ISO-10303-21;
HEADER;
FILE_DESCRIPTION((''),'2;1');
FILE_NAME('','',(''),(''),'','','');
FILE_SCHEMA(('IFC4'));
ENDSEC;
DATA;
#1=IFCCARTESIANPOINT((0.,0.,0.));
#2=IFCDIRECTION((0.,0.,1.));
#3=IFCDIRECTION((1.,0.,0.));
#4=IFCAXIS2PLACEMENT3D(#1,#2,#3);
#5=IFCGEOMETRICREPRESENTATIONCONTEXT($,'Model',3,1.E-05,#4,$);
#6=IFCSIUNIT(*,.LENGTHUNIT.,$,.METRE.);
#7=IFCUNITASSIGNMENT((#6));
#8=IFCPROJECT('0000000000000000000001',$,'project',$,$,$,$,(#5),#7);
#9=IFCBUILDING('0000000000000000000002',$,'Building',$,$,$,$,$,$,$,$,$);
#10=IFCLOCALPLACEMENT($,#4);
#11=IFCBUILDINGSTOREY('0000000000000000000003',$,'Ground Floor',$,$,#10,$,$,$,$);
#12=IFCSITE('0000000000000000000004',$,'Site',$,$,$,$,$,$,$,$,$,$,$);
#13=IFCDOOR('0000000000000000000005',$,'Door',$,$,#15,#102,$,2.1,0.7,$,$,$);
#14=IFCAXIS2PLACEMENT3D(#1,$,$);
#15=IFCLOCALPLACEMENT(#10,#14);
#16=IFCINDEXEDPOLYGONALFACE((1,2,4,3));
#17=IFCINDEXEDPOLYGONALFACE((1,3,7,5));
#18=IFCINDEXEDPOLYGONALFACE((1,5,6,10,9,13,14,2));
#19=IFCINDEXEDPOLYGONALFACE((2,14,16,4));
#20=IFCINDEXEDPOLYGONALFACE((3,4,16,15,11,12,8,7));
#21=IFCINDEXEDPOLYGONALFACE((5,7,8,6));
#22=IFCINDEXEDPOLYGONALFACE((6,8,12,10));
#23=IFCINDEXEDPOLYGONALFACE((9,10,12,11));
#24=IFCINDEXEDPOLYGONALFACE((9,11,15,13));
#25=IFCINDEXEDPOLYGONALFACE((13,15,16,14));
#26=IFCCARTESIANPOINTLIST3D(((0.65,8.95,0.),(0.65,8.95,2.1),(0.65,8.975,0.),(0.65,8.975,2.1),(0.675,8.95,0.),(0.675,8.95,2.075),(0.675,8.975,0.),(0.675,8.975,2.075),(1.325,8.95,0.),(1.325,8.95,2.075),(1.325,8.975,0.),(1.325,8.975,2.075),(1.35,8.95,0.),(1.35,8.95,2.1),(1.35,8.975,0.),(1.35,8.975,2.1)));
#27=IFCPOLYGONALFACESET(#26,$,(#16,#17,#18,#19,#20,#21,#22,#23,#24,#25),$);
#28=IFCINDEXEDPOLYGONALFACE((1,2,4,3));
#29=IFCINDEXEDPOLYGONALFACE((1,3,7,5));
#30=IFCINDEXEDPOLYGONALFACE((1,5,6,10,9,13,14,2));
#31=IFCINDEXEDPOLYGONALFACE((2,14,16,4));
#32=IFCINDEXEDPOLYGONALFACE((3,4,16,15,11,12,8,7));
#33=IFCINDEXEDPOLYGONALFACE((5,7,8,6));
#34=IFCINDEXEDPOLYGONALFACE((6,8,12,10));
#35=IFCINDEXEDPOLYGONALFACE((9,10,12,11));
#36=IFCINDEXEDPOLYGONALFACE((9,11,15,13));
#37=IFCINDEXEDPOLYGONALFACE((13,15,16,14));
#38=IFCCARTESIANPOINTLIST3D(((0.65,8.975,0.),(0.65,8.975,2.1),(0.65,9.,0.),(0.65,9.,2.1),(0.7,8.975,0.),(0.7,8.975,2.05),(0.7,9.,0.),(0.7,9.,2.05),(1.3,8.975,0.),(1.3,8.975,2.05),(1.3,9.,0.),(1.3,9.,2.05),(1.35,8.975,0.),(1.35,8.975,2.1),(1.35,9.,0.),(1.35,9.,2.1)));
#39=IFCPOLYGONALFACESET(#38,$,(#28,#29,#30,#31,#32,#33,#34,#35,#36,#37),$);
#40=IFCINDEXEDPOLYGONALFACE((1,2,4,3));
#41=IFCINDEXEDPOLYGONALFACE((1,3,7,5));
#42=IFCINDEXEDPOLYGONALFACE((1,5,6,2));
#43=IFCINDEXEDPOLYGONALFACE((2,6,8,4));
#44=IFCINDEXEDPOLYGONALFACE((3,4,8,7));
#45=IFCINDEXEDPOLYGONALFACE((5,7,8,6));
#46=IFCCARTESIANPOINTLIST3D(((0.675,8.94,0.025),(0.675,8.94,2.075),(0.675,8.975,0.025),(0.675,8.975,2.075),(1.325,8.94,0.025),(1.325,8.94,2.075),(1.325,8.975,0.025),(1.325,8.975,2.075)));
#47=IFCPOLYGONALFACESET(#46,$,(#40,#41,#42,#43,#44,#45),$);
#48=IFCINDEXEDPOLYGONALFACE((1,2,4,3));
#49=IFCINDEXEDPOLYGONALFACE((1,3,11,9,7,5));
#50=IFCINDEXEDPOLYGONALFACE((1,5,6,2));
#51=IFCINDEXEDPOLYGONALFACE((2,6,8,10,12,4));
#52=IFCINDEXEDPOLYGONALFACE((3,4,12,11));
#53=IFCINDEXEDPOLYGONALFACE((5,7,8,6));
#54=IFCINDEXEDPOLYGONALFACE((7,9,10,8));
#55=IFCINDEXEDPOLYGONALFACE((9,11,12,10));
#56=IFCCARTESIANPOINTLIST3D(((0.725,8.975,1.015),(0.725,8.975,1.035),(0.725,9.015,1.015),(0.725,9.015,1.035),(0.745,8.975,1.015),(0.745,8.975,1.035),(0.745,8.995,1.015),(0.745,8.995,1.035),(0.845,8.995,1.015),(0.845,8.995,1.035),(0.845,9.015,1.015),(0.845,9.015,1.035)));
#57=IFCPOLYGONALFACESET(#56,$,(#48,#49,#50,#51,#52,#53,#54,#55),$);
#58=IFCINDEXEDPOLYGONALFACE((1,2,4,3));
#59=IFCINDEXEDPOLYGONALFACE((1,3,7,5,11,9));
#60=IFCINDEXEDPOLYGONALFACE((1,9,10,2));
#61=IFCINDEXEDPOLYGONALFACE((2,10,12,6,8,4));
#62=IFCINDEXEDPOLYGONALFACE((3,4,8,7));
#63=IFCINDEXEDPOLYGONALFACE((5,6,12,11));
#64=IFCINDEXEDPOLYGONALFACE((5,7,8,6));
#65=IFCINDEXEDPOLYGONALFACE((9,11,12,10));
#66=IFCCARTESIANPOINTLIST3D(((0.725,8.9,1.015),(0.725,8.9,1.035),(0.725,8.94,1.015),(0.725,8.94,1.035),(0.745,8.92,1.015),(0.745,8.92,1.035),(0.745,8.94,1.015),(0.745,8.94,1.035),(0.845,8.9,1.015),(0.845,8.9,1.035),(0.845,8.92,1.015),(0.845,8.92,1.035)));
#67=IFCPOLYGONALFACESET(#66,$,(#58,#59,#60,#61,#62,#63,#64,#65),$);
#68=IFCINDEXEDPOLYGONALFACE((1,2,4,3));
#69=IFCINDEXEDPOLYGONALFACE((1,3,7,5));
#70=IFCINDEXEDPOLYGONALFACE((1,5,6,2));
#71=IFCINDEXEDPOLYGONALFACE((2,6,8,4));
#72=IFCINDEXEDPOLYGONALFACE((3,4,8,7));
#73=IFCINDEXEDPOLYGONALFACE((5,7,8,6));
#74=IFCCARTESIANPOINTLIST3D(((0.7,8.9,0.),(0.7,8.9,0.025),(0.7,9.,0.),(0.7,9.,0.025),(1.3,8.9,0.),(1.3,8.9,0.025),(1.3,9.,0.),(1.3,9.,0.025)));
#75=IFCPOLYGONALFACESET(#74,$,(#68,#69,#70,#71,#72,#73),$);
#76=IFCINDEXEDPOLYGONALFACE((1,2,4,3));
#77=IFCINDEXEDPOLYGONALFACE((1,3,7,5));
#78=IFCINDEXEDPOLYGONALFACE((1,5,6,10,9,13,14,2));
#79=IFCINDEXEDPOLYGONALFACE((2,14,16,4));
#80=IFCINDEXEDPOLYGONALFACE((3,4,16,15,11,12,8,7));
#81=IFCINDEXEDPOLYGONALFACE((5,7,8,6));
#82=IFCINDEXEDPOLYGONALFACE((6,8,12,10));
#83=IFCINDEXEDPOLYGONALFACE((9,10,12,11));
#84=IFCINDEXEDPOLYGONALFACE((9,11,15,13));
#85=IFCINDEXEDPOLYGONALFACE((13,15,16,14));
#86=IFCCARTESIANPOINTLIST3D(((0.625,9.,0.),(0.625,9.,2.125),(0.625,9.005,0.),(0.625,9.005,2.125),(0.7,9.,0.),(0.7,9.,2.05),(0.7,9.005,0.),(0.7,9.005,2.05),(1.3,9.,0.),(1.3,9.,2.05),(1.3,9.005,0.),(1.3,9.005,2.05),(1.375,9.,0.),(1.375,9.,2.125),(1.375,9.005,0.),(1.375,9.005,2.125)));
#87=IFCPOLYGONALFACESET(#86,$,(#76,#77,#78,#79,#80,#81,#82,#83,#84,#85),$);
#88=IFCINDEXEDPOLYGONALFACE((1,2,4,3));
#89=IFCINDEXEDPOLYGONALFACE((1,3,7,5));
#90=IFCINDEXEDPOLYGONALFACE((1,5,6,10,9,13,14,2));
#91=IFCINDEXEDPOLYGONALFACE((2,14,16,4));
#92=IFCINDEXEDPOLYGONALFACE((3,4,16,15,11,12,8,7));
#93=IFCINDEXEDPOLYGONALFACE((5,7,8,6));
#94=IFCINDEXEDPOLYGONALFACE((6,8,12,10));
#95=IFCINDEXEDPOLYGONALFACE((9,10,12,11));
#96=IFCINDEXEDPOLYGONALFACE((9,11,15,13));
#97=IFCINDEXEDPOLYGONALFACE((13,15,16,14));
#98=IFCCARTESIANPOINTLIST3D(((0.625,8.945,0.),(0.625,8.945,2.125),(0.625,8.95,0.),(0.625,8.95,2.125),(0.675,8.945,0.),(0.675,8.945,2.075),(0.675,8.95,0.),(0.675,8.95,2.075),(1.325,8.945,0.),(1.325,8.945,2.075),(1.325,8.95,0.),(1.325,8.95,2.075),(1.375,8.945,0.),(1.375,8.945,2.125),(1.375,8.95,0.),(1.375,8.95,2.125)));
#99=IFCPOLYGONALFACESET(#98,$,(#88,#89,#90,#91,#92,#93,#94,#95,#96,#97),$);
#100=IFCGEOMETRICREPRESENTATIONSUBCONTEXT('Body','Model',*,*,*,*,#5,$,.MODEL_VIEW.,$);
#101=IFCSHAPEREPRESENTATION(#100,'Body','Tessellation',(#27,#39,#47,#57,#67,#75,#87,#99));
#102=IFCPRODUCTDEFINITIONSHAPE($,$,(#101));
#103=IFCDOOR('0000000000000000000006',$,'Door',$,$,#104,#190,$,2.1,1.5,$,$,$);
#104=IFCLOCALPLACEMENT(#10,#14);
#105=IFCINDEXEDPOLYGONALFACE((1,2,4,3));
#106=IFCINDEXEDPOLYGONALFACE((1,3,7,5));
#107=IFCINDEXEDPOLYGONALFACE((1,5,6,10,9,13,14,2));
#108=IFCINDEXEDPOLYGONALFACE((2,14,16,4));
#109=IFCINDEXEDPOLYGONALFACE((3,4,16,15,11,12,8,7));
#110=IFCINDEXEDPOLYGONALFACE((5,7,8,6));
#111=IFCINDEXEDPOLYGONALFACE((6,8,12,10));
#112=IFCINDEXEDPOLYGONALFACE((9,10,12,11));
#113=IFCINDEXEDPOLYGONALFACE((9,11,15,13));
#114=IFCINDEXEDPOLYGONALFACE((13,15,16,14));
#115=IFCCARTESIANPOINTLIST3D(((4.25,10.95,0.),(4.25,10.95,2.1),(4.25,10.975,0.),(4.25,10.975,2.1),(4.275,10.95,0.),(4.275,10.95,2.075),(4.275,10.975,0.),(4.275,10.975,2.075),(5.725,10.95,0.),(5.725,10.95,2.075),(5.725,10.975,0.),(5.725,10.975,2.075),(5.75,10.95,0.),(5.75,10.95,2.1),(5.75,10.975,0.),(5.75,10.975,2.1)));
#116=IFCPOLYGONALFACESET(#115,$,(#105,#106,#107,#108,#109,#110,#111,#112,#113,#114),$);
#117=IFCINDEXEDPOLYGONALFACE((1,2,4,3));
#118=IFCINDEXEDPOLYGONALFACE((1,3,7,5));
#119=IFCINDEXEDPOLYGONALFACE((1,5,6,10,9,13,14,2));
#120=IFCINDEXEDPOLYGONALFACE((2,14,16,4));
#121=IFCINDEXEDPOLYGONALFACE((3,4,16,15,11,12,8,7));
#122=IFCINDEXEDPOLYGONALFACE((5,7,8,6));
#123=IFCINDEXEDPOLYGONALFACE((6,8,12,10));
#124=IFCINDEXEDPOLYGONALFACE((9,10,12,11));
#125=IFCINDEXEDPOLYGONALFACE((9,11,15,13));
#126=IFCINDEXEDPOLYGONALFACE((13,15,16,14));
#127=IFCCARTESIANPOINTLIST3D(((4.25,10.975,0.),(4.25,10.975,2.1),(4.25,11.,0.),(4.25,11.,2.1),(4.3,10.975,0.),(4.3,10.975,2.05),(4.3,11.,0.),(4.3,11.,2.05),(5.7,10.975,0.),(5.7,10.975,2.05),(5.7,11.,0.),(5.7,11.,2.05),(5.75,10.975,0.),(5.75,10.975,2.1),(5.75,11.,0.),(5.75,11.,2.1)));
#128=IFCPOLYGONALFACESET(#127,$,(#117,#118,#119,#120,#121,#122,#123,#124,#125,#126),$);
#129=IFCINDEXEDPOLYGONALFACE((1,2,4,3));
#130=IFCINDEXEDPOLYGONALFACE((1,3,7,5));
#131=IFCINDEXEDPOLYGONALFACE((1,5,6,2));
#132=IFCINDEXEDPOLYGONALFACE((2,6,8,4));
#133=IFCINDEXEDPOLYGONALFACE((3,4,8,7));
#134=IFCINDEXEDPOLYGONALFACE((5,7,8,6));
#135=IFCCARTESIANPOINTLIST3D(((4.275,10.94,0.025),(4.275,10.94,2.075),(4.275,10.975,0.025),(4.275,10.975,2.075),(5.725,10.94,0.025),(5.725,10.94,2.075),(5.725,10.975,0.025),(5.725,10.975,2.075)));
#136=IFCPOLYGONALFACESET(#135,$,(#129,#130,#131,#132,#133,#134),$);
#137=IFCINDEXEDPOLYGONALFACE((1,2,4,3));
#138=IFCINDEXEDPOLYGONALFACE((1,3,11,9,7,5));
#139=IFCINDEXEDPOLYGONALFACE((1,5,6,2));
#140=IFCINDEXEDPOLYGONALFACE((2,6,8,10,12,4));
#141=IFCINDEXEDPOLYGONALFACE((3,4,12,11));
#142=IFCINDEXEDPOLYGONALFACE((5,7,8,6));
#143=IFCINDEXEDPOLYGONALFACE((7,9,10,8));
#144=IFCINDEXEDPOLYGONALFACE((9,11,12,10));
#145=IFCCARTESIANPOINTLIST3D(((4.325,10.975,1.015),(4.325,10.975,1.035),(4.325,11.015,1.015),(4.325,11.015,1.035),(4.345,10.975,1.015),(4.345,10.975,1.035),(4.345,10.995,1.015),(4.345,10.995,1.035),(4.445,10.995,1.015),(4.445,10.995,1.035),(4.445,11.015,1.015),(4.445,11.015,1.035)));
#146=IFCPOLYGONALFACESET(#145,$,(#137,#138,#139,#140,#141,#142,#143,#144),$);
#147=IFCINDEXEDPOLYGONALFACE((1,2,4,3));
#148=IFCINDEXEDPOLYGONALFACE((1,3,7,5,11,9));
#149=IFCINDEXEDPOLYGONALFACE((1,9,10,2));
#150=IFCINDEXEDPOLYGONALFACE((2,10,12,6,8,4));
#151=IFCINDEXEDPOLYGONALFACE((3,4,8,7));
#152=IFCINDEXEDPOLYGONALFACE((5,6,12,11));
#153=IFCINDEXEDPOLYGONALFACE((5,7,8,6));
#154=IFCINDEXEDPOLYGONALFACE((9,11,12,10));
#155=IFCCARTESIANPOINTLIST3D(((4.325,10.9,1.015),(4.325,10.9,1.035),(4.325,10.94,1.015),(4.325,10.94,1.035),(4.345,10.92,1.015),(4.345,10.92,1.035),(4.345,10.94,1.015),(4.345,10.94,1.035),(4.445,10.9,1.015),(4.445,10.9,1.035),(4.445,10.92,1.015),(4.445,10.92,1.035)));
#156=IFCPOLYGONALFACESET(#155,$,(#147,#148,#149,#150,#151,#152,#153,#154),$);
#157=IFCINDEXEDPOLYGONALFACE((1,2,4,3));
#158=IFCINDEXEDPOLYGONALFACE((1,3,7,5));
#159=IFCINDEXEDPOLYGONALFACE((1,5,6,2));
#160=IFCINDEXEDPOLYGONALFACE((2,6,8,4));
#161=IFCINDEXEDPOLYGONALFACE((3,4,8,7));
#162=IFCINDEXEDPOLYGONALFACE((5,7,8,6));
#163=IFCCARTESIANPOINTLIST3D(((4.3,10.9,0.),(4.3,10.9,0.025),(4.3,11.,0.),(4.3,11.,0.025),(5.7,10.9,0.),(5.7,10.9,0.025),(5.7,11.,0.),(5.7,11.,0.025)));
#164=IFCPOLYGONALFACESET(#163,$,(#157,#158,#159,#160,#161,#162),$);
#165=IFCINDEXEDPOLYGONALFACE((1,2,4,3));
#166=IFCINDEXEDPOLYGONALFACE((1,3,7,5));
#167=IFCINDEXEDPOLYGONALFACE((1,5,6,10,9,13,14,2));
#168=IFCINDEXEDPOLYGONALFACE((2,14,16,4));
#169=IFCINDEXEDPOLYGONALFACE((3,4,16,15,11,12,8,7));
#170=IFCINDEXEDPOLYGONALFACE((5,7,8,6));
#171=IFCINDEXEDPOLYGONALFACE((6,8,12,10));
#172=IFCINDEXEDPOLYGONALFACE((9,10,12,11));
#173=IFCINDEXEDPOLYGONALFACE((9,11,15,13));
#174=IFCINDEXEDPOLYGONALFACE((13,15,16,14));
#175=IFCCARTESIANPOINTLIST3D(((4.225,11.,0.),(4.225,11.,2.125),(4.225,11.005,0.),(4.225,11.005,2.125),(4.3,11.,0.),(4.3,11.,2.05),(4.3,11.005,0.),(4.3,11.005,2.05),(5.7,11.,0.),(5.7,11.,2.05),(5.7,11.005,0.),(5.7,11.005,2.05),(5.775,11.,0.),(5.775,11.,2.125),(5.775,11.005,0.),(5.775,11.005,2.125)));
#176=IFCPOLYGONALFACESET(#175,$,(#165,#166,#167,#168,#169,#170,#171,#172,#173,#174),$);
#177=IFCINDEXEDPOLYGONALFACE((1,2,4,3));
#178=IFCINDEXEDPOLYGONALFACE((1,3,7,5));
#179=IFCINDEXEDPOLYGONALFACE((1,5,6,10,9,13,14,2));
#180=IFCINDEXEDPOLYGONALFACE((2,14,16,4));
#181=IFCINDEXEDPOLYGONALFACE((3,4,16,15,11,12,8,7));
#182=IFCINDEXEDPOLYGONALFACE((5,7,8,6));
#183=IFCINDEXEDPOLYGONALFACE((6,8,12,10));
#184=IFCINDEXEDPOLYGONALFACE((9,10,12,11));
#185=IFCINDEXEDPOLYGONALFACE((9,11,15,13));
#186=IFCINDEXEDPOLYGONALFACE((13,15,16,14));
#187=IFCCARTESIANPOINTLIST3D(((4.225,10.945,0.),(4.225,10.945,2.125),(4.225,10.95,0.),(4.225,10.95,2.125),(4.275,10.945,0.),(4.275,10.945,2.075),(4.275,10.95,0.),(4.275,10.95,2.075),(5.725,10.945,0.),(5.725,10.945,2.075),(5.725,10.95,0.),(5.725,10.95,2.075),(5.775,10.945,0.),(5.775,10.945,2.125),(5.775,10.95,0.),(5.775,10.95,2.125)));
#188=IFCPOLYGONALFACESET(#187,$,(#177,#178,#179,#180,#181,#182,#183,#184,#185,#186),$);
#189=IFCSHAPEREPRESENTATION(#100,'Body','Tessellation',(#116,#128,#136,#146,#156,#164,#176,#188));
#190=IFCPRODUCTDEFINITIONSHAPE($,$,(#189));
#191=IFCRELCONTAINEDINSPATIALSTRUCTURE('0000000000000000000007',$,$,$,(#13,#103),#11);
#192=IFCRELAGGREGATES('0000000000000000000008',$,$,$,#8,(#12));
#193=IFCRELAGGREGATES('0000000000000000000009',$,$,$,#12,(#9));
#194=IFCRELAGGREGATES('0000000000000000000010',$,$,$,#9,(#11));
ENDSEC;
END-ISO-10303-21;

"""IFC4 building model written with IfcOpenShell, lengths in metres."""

from ifc_helpers import new_model, si_unit, frame, origin_with_axes, place, context, subcontext, project, spatial, line, indexed_curve, outline, extrude, element, save


model = new_model("IFC4")

# Units and contexts
model_context = context("Model", 3, precision=1e-05, world=origin_with_axes())
body_context = subcontext(model_context, "Body", "Model", "MODEL_VIEW")
ifc_project = project(units=[si_unit("LENGTHUNIT", "METRE")], contexts=[model_context])

# Site, building, storey
site = spatial("IfcSite", under=ifc_project, Name="Site")
building = spatial("IfcBuilding", under=site, Name="Building")
storey_placement = place(None, origin_with_axes())
storey = spatial("IfcBuildingStorey", under=building, at=storey_placement, Name="Ground Floor")

# Doors
door_1_placement = place(storey_placement, frame((1.35, 9.0, 0.0), z_axis=(0.0, 0.0, 1.0), x_axis=(-1.0, 0.0, 0.0)))
element("IfcDoor", 1, at=door_1_placement, inside=storey, Name="Door", OverallHeight=2.1, OverallWidth=0.7, context=body_context, shape_type="SweptSolid", body=[
    extrude(outline(indexed_curve([(0.0, 0.0), (0.0, 2.1), (0.7, 2.1), (0.7, 0.0), (0.675, 0.0), (0.675, 2.075), (0.025, 2.075), (0.025, 0.0)], segments=[line(1, 2, 3, 4, 5, 6, 7, 8, 1)])), frame((0.0, 0.025, 0.0), z_axis=(0.0, -1.0, 0.0), x_axis=(1.0, 0.0, 0.0)), (0.0, 0.0, -1.0), 0.025),
    extrude(outline(indexed_curve([(0.0, 0.0), (0.0, 2.1), (0.7, 2.1), (0.7, 0.0), (0.65, 0.0), (0.65, 2.05), (0.05, 2.05), (0.05, 0.0)], segments=[line(1, 2, 3, 4, 5, 6, 7, 8, 1)])), frame((0.0, 0.0, 0.0), z_axis=(0.0, -1.0, 0.0), x_axis=(1.0, 0.0, 0.0)), (0.0, 0.0, -1.0), 0.025),
    extrude(outline(indexed_curve([(0.0, 0.0), (0.65, 0.0), (0.65, 0.035), (0.0, 0.035)], segments=[line(1, 2, 3, 4, 1)])), frame((0.025, 0.025, 0.025), z_axis=(0.0, 0.0, 1.0), x_axis=(1.0, 0.0, 0.0)), (0.0, 0.0, 1.0), 2.05),
    extrude(outline(indexed_curve([(0.0, 0.0), (0.0, -0.04), (-0.12, -0.04), (-0.12, -0.02), (-0.02, -0.02), (-0.02, 0.0)], segments=[line(1, 2, 3, 4, 5, 6, 1)])), frame((0.625, 0.025, 1.015), z_axis=(0.0, 0.0, 1.0), x_axis=(1.0, 0.0, 0.0)), (0.0, 0.0, 1.0), 0.02),
    extrude(outline(indexed_curve([(0.0, 0.0), (0.0, 0.04), (-0.12, 0.04), (-0.12, 0.02), (-0.02, 0.02), (-0.02, 0.0)], segments=[line(1, 2, 3, 4, 5, 6, 1)])), frame((0.625, 0.06, 1.015), z_axis=(0.0, 0.0, 1.0), x_axis=(1.0, 0.0, 0.0)), (0.0, 0.0, 1.0), 0.02),
    extrude(outline(indexed_curve([(0.0, 0.0), (0.6, 0.0), (0.6, 0.1), (0.0, 0.1)], segments=[line(1, 2, 3, 4, 1)])), frame((0.05, 0.0, 0.0), z_axis=(0.0, 0.0, 1.0), x_axis=(1.0, 0.0, 0.0)), (0.0, 0.0, 1.0), 0.025),
    extrude(outline(indexed_curve([(0.0, 0.0), (0.0, 2.125), (0.75, 2.125), (0.75, 0.0), (0.675, 0.0), (0.675, 2.05), (0.075, 2.05), (0.075, 0.0)], segments=[line(1, 2, 3, 4, 5, 6, 7, 8, 1)])), frame((-0.025, -0.005, 0.0), z_axis=(0.0, -1.0, 0.0), x_axis=(1.0, 0.0, 0.0)), (0.0, 0.0, -1.0), 0.005),
    extrude(outline(indexed_curve([(0.0, 0.0), (0.0, 2.125), (0.75, 2.125), (0.75, 0.0), (0.7, 0.0), (0.7, 2.075), (0.05, 2.075), (0.05, 0.0)], segments=[line(1, 2, 3, 4, 5, 6, 7, 8, 1)])), frame((-0.025, 0.05, 0.0), z_axis=(0.0, -1.0, 0.0), x_axis=(1.0, 0.0, 0.0)), (0.0, 0.0, -1.0), 0.005),
])
door_2_placement = place(storey_placement, frame((5.75, 11.0, 0.0), z_axis=(0.0, 0.0, 1.0), x_axis=(-1.0, 0.0, 0.0)))
element("IfcDoor", 2, at=door_2_placement, inside=storey, Name="Door", OverallHeight=2.1, OverallWidth=1.5, context=body_context, shape_type="SweptSolid", body=[
    extrude(outline(indexed_curve([(0.0, 0.0), (0.0, 2.1), (1.5, 2.1), (1.5, 0.0), (1.475, 0.0), (1.475, 2.075), (0.025, 2.075), (0.025, 0.0)], segments=[line(1, 2, 3, 4, 5, 6, 7, 8, 1)])), frame((0.0, 0.025, 0.0), z_axis=(0.0, -1.0, 0.0), x_axis=(1.0, 0.0, 0.0)), (0.0, 0.0, -1.0), 0.025),
    extrude(outline(indexed_curve([(0.0, 0.0), (0.0, 2.1), (1.5, 2.1), (1.5, 0.0), (1.45, 0.0), (1.45, 2.05), (0.05, 2.05), (0.05, 0.0)], segments=[line(1, 2, 3, 4, 5, 6, 7, 8, 1)])), frame((0.0, 0.0, 0.0), z_axis=(0.0, -1.0, 0.0), x_axis=(1.0, 0.0, 0.0)), (0.0, 0.0, -1.0), 0.025),
    extrude(outline(indexed_curve([(0.0, 0.0), (1.45, 0.0), (1.45, 0.035), (0.0, 0.035)], segments=[line(1, 2, 3, 4, 1)])), frame((0.025, 0.025, 0.025), z_axis=(0.0, 0.0, 1.0), x_axis=(1.0, 0.0, 0.0)), (0.0, 0.0, 1.0), 2.05),
    extrude(outline(indexed_curve([(0.0, 0.0), (0.0, -0.04), (-0.12, -0.04), (-0.12, -0.02), (-0.02, -0.02), (-0.02, 0.0)], segments=[line(1, 2, 3, 4, 5, 6, 1)])), frame((1.425, 0.025, 1.015), z_axis=(0.0, 0.0, 1.0), x_axis=(1.0, 0.0, 0.0)), (0.0, 0.0, 1.0), 0.02),
    extrude(outline(indexed_curve([(0.0, 0.0), (0.0, 0.04), (-0.12, 0.04), (-0.12, 0.02), (-0.02, 0.02), (-0.02, 0.0)], segments=[line(1, 2, 3, 4, 5, 6, 1)])), frame((1.425, 0.06, 1.015), z_axis=(0.0, 0.0, 1.0), x_axis=(1.0, 0.0, 0.0)), (0.0, 0.0, 1.0), 0.02),
    extrude(outline(indexed_curve([(0.0, 0.0), (1.4, 0.0), (1.4, 0.1), (0.0, 0.1)], segments=[line(1, 2, 3, 4, 1)])), frame((0.05, 0.0, 0.0), z_axis=(0.0, 0.0, 1.0), x_axis=(1.0, 0.0, 0.0)), (0.0, 0.0, 1.0), 0.025),
    extrude(outline(indexed_curve([(0.0, 0.0), (0.0, 2.125), (1.55, 2.125), (1.55, 0.0), (1.475, 0.0), (1.475, 2.05), (0.075, 2.05), (0.075, 0.0)], segments=[line(1, 2, 3, 4, 5, 6, 7, 8, 1)])), frame((-0.025, -0.005, 0.0), z_axis=(0.0, -1.0, 0.0), x_axis=(1.0, 0.0, 0.0)), (0.0, 0.0, -1.0), 0.005),
    extrude(outline(indexed_curve([(0.0, 0.0), (0.0, 2.125), (1.55, 2.125), (1.55, 0.0), (1.5, 0.0), (1.5, 2.075), (0.05, 2.075), (0.05, 0.0)], segments=[line(1, 2, 3, 4, 5, 6, 7, 8, 1)])), frame((-0.025, 0.05, 0.0), z_axis=(0.0, -1.0, 0.0), x_axis=(1.0, 0.0, 0.0)), (0.0, 0.0, -1.0), 0.005),
])

save(model, "model.ifc")
